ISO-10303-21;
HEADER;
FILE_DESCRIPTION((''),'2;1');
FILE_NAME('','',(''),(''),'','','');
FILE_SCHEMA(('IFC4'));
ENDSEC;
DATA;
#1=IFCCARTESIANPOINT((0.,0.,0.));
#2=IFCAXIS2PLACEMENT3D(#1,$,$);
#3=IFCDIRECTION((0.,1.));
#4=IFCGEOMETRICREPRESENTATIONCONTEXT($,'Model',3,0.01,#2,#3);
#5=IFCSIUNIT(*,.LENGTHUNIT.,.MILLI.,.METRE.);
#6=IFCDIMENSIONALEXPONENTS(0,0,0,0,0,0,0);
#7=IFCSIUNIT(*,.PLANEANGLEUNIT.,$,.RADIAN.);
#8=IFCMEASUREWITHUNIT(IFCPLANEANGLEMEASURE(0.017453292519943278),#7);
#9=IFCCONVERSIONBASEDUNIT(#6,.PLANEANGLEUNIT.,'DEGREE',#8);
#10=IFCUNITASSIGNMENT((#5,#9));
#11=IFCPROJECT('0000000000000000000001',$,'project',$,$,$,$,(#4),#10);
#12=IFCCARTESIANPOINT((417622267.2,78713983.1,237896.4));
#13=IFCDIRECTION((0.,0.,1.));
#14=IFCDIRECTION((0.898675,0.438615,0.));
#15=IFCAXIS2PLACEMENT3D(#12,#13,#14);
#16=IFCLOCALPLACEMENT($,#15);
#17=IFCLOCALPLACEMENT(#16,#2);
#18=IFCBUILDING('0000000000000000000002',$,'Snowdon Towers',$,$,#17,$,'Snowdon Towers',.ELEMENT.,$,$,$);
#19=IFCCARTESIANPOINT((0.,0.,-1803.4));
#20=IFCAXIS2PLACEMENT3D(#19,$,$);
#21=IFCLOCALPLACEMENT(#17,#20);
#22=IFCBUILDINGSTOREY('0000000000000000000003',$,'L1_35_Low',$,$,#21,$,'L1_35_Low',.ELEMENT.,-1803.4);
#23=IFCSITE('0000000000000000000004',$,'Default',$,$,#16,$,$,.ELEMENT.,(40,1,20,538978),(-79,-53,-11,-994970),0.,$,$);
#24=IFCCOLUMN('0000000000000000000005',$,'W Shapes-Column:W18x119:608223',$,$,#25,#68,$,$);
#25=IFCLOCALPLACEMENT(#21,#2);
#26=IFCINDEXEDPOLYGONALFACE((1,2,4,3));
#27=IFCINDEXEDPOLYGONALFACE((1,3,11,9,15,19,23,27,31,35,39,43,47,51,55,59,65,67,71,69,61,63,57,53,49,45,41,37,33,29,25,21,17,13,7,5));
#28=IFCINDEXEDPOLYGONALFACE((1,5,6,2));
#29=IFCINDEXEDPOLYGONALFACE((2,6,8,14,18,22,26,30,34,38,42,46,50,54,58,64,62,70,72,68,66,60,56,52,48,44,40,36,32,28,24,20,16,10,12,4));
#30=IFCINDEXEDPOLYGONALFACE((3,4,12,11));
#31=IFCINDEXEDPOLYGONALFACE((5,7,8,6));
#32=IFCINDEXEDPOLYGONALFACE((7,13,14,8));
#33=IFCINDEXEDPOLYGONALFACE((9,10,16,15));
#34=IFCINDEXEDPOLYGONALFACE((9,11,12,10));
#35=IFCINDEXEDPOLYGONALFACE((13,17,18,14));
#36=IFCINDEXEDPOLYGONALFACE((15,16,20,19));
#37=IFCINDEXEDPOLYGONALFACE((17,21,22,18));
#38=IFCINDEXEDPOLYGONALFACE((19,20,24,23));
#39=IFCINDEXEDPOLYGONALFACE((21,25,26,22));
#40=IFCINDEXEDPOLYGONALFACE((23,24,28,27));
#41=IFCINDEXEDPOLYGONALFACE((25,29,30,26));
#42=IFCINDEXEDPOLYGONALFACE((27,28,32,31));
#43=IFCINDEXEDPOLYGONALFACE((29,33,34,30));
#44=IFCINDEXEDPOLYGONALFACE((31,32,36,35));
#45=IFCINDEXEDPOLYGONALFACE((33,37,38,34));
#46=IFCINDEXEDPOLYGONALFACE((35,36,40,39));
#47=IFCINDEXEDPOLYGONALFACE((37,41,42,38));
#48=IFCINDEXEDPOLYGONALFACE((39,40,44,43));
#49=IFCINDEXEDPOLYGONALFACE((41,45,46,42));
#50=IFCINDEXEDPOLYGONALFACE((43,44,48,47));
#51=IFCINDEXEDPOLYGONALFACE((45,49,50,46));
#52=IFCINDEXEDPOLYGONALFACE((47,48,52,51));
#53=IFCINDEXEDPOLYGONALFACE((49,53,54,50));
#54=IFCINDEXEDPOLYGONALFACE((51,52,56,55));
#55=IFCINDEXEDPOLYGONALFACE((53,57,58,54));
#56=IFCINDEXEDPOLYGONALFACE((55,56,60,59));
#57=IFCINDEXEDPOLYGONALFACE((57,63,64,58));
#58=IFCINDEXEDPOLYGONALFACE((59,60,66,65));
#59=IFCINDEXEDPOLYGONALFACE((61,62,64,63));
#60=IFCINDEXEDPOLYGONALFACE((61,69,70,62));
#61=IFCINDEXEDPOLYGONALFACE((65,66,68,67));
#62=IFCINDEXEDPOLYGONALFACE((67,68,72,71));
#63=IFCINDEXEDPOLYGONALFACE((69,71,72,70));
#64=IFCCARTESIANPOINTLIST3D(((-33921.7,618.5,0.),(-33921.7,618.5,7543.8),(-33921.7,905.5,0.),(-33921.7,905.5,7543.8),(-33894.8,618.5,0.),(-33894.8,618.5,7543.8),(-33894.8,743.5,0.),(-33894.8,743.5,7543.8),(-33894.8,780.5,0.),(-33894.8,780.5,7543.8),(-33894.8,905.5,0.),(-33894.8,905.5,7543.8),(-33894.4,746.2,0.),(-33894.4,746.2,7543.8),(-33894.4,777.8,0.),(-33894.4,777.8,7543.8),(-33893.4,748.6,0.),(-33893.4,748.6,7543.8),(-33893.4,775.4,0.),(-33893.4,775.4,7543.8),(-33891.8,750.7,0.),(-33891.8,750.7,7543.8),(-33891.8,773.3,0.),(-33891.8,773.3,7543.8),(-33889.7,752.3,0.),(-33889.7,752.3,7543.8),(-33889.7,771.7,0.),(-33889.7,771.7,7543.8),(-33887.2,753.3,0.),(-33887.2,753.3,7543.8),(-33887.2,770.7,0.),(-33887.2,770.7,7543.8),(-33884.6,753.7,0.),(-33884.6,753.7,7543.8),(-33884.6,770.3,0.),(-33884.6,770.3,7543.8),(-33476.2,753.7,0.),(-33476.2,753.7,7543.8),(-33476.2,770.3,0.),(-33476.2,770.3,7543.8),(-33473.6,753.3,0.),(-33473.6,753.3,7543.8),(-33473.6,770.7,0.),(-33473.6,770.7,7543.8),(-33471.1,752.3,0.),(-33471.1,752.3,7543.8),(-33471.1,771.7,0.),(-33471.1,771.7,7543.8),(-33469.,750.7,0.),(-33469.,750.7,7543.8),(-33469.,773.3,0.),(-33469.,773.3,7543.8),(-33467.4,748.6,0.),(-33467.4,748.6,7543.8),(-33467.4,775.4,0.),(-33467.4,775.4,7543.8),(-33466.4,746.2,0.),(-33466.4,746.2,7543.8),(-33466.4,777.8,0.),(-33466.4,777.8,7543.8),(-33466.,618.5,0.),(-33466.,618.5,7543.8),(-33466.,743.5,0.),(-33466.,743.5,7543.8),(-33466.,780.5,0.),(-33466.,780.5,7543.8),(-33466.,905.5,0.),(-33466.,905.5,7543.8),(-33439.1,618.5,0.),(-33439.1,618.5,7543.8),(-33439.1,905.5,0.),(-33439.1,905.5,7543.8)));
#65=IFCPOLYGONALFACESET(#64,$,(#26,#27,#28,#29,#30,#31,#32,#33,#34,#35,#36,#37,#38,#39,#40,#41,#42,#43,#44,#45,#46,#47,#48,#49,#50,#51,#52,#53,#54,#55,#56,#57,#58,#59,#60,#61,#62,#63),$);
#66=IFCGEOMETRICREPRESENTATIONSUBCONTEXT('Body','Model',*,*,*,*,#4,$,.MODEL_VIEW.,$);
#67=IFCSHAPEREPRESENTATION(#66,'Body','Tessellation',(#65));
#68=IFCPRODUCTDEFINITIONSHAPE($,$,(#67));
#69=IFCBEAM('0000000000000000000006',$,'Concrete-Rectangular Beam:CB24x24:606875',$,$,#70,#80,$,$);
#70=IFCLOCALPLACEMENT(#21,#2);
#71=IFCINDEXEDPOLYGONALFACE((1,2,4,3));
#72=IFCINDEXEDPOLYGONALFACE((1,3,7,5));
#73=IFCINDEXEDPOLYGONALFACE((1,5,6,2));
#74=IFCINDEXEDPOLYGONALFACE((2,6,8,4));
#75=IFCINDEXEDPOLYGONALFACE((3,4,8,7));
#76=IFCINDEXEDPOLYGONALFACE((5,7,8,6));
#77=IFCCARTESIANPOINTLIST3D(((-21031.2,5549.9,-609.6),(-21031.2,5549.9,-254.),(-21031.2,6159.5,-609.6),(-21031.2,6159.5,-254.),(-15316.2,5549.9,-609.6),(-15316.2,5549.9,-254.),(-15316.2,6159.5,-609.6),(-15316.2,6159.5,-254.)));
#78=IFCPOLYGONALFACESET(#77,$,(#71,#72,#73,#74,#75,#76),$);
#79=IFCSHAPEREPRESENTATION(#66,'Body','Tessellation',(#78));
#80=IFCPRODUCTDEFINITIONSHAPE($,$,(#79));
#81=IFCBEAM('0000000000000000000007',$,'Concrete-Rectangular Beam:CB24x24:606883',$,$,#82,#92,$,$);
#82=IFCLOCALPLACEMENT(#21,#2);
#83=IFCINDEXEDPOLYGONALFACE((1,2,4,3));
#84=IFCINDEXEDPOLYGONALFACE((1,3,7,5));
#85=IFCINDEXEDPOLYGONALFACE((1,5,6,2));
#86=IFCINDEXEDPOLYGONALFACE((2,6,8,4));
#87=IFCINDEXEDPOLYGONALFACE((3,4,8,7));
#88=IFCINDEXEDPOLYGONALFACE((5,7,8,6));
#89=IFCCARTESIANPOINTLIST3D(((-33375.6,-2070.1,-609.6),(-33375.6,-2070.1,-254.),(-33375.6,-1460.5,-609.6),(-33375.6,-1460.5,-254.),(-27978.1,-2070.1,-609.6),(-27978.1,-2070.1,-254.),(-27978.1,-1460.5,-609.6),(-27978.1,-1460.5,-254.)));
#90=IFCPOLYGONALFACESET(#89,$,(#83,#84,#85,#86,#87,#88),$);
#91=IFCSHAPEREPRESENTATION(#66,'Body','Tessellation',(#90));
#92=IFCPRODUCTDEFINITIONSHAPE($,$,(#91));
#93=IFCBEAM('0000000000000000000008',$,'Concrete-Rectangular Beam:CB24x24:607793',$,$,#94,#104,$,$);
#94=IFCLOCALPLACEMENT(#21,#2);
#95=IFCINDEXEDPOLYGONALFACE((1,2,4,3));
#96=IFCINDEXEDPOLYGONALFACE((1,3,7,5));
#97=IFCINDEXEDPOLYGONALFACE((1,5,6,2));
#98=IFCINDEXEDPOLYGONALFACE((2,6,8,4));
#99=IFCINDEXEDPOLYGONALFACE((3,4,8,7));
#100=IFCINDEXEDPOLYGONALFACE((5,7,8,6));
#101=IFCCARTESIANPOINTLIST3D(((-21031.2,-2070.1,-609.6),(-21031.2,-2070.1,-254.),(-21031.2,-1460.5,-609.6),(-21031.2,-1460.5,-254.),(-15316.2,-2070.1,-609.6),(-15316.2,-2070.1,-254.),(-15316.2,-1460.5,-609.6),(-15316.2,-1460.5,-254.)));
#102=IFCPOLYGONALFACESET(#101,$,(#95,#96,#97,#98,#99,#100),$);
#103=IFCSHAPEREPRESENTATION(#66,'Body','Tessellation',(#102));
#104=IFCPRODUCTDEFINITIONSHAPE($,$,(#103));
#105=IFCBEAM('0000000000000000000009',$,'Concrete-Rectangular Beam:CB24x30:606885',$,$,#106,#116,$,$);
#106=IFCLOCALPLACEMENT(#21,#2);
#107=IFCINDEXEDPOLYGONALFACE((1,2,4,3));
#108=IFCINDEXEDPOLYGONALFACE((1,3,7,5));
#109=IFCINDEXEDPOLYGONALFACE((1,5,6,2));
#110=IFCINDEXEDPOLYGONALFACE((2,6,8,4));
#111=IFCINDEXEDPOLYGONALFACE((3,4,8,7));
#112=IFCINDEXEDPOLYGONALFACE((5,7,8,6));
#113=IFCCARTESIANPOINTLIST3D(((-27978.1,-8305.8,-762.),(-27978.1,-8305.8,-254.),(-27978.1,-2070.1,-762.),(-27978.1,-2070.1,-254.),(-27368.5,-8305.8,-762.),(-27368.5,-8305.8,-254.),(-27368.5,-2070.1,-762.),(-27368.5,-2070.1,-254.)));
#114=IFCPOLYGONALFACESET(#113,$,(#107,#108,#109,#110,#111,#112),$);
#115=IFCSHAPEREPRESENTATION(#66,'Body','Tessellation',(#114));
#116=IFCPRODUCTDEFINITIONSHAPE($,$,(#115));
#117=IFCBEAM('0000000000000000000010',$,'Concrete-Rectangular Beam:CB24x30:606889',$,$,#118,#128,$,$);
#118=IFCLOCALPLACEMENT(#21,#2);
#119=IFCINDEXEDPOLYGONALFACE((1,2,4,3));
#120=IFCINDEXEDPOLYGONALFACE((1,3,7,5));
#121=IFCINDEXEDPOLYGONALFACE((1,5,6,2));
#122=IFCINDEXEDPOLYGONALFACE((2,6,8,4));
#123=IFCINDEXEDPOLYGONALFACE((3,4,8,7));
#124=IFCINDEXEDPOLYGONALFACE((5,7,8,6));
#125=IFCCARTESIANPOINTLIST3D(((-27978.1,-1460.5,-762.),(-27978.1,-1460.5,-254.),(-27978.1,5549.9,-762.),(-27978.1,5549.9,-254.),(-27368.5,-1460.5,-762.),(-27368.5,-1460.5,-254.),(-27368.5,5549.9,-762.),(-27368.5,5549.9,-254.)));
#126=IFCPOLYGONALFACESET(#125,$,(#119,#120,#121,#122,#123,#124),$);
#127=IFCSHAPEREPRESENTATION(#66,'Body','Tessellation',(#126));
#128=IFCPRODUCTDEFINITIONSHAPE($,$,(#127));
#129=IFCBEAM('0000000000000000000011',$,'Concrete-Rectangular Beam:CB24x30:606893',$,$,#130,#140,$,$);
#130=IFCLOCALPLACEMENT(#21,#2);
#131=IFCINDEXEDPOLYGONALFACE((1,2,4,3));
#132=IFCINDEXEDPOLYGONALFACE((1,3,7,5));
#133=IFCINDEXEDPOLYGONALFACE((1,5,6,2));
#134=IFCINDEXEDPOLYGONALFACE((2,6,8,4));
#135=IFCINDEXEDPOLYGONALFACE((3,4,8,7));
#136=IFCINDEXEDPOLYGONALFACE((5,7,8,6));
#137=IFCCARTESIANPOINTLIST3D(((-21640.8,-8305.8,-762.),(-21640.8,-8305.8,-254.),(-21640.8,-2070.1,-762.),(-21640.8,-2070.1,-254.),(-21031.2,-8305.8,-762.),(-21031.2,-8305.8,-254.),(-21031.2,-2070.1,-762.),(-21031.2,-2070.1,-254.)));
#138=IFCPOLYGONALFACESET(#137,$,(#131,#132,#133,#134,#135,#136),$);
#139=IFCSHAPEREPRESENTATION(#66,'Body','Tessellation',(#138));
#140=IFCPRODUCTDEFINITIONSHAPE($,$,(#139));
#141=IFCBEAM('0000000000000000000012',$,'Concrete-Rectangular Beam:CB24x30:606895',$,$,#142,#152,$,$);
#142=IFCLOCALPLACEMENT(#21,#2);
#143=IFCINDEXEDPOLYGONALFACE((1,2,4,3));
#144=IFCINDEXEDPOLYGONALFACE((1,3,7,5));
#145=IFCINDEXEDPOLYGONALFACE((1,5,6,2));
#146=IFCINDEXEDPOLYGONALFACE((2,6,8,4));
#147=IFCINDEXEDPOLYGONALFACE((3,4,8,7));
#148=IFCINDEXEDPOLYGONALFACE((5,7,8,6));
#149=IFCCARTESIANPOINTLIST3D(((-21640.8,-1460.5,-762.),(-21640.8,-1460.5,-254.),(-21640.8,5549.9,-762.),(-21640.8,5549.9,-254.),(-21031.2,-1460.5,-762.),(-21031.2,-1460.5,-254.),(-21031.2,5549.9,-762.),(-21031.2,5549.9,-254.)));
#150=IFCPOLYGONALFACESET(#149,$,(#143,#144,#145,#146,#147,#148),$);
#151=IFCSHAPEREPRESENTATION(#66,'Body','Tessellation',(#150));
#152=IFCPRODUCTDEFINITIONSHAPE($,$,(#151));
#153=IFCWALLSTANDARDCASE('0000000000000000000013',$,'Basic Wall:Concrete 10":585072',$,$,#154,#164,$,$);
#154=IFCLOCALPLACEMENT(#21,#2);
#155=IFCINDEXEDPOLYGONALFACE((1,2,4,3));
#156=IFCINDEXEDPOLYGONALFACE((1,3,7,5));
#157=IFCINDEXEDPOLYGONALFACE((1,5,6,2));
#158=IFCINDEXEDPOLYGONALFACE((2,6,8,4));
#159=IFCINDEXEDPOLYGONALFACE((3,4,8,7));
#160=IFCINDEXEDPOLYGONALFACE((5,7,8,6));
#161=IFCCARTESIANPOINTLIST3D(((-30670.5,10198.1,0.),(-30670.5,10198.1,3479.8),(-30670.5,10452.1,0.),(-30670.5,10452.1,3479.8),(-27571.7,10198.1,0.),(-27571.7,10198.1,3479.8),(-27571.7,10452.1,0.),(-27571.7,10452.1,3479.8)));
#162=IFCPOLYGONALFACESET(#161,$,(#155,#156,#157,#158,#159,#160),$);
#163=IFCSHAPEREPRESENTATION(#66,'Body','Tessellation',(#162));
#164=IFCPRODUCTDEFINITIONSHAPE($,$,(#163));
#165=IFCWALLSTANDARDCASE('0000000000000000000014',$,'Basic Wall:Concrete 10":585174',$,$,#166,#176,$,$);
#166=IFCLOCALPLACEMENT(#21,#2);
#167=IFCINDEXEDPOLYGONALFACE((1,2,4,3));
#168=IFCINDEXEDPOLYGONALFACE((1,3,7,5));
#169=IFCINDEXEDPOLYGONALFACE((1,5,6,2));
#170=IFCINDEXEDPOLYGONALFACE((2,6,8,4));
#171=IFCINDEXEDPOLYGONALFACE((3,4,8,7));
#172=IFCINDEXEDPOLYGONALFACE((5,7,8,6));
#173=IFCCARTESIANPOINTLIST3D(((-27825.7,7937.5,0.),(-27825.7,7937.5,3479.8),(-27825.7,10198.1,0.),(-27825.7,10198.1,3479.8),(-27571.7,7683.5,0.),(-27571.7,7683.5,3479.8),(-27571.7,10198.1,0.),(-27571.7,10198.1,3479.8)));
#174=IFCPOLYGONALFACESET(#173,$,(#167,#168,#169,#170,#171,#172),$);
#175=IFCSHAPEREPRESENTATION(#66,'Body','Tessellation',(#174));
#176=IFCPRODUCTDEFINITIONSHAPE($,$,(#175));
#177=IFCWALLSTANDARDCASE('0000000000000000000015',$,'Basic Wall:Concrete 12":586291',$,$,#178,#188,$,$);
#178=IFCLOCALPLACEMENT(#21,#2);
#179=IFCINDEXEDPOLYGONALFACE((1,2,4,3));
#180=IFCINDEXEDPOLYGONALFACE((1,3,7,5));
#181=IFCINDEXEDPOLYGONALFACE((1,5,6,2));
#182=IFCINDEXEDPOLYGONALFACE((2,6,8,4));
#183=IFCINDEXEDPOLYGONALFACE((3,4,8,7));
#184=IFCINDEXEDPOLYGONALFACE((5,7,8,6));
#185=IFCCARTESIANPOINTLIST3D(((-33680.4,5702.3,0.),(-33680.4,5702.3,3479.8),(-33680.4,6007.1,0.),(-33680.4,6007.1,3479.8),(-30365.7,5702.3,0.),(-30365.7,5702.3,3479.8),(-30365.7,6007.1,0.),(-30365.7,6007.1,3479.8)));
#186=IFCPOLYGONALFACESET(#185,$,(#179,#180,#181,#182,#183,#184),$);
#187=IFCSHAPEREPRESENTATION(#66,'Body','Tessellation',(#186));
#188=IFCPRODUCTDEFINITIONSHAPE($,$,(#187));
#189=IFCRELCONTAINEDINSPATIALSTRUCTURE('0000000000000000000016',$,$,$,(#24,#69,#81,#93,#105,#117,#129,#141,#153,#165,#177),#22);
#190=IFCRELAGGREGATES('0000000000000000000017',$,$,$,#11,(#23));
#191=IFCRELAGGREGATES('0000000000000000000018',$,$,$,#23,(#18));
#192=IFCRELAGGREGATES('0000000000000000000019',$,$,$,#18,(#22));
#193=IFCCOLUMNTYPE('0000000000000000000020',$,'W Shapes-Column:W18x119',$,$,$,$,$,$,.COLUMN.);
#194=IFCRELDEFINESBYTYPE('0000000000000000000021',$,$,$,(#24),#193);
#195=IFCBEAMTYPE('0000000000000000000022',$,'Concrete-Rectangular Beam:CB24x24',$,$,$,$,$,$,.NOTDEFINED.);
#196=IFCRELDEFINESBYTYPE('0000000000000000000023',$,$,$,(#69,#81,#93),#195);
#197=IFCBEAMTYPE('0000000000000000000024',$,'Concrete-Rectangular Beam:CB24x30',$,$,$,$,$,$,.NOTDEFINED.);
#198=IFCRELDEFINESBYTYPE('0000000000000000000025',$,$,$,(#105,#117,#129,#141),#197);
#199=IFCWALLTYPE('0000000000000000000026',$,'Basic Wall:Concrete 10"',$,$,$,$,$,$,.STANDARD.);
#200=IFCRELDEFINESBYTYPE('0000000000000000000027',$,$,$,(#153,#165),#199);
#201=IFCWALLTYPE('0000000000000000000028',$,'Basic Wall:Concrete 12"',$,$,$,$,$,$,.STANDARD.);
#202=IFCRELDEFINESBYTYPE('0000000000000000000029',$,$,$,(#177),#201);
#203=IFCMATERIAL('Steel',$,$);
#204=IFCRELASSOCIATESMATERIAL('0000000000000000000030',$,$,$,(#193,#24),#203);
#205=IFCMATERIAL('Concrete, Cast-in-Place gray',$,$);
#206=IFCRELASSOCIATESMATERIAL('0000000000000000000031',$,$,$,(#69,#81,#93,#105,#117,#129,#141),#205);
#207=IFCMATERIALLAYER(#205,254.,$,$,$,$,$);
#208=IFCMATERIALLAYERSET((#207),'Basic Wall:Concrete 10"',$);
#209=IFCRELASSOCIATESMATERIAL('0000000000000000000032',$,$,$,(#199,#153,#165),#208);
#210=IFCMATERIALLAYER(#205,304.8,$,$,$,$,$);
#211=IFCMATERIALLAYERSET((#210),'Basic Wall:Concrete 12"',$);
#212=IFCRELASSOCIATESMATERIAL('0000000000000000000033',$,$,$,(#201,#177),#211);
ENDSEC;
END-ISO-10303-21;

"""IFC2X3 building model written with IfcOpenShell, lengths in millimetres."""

from ifc_helpers import new_model, entity, si_unit, converted_unit, direction, frame, frame_2d, origin, place, context, subcontext, project, spatial, polyline, rectangle, i_section, outline, extrude, source, transform, mapped, material, layer, layer_set, layer_usage, type_object, type_shapes, element, save


model = new_model("IFC2X3")

# Units and contexts
model_context = context("Model", 3, precision=0.01, world=origin(), true_north=direction((0.0, 1.0)))
body_context = subcontext(model_context, "Body", "Model", "MODEL_VIEW")
ifc_project = project(units=[si_unit("LENGTHUNIT", "METRE", prefix="MILLI"), converted_unit("PLANEANGLEUNIT", "DEGREE", entity("IfcPlaneAngleMeasure", 0.017453292519943278), si_unit("PLANEANGLEUNIT", "RADIAN"), dimensions=[0, 0, 0, 0, 0, 0, 0])], contexts=[model_context])

# Site, building, storey
site_placement = place(None, frame((417622267.2, 78713983.1, 237896.4), z_axis=(0.0, 0.0, 1.0), x_axis=(0.898675, 0.438615, 0.0)))
site = spatial("IfcSite", under=ifc_project, at=site_placement, Name="Default", CompositionType="ELEMENT", RefLatitude=(40, 1, 20, 538978), RefLongitude=(-79, -53, -11, -994970), RefElevation=0.0)
building_placement = place(site_placement, origin())
building = spatial("IfcBuilding", under=site, at=building_placement, Name="Snowdon Towers", LongName="Snowdon Towers", CompositionType="ELEMENT")
storey_placement = place(building_placement, frame((0.0, 0.0, -1803.4)))
storey = spatial("IfcBuildingStorey", under=building, at=storey_placement, Name="L1_35_Low", LongName="L1_35_Low", CompositionType="ELEMENT", Elevation=-1803.4)

# Column
ifc_material_1 = material(Name="Steel")
column_type_1 = type_object("IfcColumnType", Name="W Shapes-Column:W18x119", PredefinedType="COLUMN", material=ifc_material_1)
shared_shape_1 = source(origin(), body_context, "Body", "SweptSolid", [
    extrude(i_section(OverallWidth=287.0, OverallDepth=482.6, WebThickness=16.6, FlangeThickness=26.9, FilletRadius=10.2, at=frame_2d((0.0, 0.0), x_axis=(1.0, 0.0))), frame((0.0, 0.0, -1803.4), z_axis=(0.0, 0.0, 1.0), x_axis=(-1.0, 0.0, 0.0)), (0.0, 0.0, 1.0), 7543.8),
])
type_shapes(column_type_1, [shared_shape_1])
column_placement = place(storey_placement, frame((-33680.4, 762.0, 1803.4), z_axis=(0.0, 0.0, 1.0), x_axis=(0.0, -1.0, 0.0)))
element("IfcColumn", 1, at=column_placement, inside=storey, type_object=column_type_1, material=ifc_material_1, Name="W Shapes-Column:W18x119:608223", context=body_context, shape_type="MappedRepresentation", body=[
    mapped(shared_shape_1, transform((0.0, 0.0, 0.0), scale=1.0)),
])

# Beams
ifc_material_2 = material(Name="Concrete, Cast-in-Place gray")
beam_type_1 = type_object("IfcBeamType", Name="Concrete-Rectangular Beam:CB24x24", PredefinedType="NOTDEFINED")
beam_1_placement = place(storey_placement, frame((-21336.0, 5854.7, 0.0)))
element("IfcBeam", 2, at=beam_1_placement, inside=storey, type_object=beam_type_1, material=ifc_material_2, Name="Concrete-Rectangular Beam:CB24x24:606875", context=body_context, shape_type="SweptSolid", body=[
    extrude(rectangle(XDim=355.6, YDim=609.6, at=frame_2d((0.0, 0.0), x_axis=(1.0, 0.0))), frame((304.8, 0.0, -431.8), z_axis=(1.0, 0.0, 0.0), x_axis=(0.0, 0.0, -1.0)), (0.0, 0.0, 1.0), 5715.0),
])
beam_2_placement = place(storey_placement, frame((-33680.4, -1765.3, 0.0)))
element("IfcBeam", 3, at=beam_2_placement, inside=storey, type_object=beam_type_1, material=ifc_material_2, Name="Concrete-Rectangular Beam:CB24x24:606883", context=body_context, shape_type="SweptSolid", body=[
    extrude(rectangle(XDim=355.6, YDim=609.6, at=frame_2d((0.0, 0.0), x_axis=(1.0, 0.0))), frame((304.8, 0.0, -431.8), z_axis=(1.0, 0.0, 0.0), x_axis=(0.0, 0.0, -1.0)), (0.0, 0.0, 1.0), 5397.5),
])
beam_3_placement = place(storey_placement, frame((-21336.0, -1765.3, 0.0)))
element("IfcBeam", 4, at=beam_3_placement, inside=storey, type_object=beam_type_1, material=ifc_material_2, Name="Concrete-Rectangular Beam:CB24x24:607793", context=body_context, shape_type="SweptSolid", body=[
    extrude(rectangle(XDim=355.6, YDim=609.6, at=frame_2d((0.0, 0.0), x_axis=(1.0, 0.0))), frame((304.8, 0.0, -431.8), z_axis=(1.0, 0.0, 0.0), x_axis=(0.0, 0.0, -1.0)), (0.0, 0.0, 1.0), 5715.0),
])
beam_type_2 = type_object("IfcBeamType", Name="Concrete-Rectangular Beam:CB24x30", PredefinedType="NOTDEFINED")
beam_4_placement = place(storey_placement, frame((-27673.3, -8610.6, 0.0), z_axis=(0.0, 0.0, 1.0), x_axis=(0.0, 1.0, 0.0)))
element("IfcBeam", 5, at=beam_4_placement, inside=storey, type_object=beam_type_2, material=ifc_material_2, Name="Concrete-Rectangular Beam:CB24x30:606885", context=body_context, shape_type="SweptSolid", body=[
    extrude(rectangle(XDim=508.0, YDim=609.6, at=frame_2d((0.0, 0.0), x_axis=(1.0, 0.0))), frame((304.8, 0.0, -508.0), z_axis=(1.0, 0.0, 0.0), x_axis=(0.0, 0.0, -1.0)), (0.0, 0.0, 1.0), 6235.7),
])
beam_5_placement = place(storey_placement, frame((-27673.3, -1765.3, 0.0), z_axis=(0.0, 0.0, 1.0), x_axis=(0.0, 1.0, 0.0)))
element("IfcBeam", 6, at=beam_5_placement, inside=storey, type_object=beam_type_2, material=ifc_material_2, Name="Concrete-Rectangular Beam:CB24x30:606889", context=body_context, shape_type="SweptSolid", body=[
    extrude(rectangle(XDim=508.0, YDim=609.6, at=frame_2d((0.0, 0.0), x_axis=(1.0, 0.0))), frame((304.8, 0.0, -508.0), z_axis=(1.0, 0.0, 0.0), x_axis=(0.0, 0.0, -1.0)), (0.0, 0.0, 1.0), 7010.4),
])
beam_6_placement = place(storey_placement, frame((-21336.0, -8610.6, 0.0), z_axis=(0.0, 0.0, 1.0), x_axis=(0.0, 1.0, 0.0)))
element("IfcBeam", 7, at=beam_6_placement, inside=storey, type_object=beam_type_2, material=ifc_material_2, Name="Concrete-Rectangular Beam:CB24x30:606893", context=body_context, shape_type="SweptSolid", body=[
    extrude(rectangle(XDim=508.0, YDim=609.6, at=frame_2d((0.0, 0.0), x_axis=(1.0, 0.0))), frame((304.8, 0.0, -508.0), z_axis=(1.0, 0.0, 0.0), x_axis=(0.0, 0.0, -1.0)), (0.0, 0.0, 1.0), 6235.7),
])
beam_7_placement = place(storey_placement, frame((-21336.0, -1765.3, 0.0), z_axis=(0.0, 0.0, 1.0), x_axis=(0.0, 1.0, 0.0)))
element("IfcBeam", 8, at=beam_7_placement, inside=storey, type_object=beam_type_2, material=ifc_material_2, Name="Concrete-Rectangular Beam:CB24x30:606895", context=body_context, shape_type="SweptSolid", body=[
    extrude(rectangle(XDim=508.0, YDim=609.6, at=frame_2d((0.0, 0.0), x_axis=(1.0, 0.0))), frame((304.8, 0.0, -508.0), z_axis=(1.0, 0.0, 0.0), x_axis=(0.0, 0.0, -1.0)), (0.0, 0.0, 1.0), 7010.4),
])

# Walls
ifc_layer_1 = layer(ifc_material_2, 254.0)
ifc_layer_set_1 = layer_set([ifc_layer_1], Name="Basic Wall:Concrete 10\"")
ifc_layer_usage_1 = layer_usage(ifc_layer_set_1, "AXIS2", "POSITIVE", -127.0)
wall_type_1 = type_object("IfcWallType", Name="Basic Wall:Concrete 10\"", PredefinedType="STANDARD", material=ifc_layer_set_1)
wall_1_placement = place(storey_placement, frame((-30670.5, 10325.1, 0.0)))
element("IfcWallStandardCase", 9, at=wall_1_placement, inside=storey, type_object=wall_type_1, material=ifc_layer_usage_1, Name="Basic Wall:Concrete 10\":585072", context=body_context, shape_type="SweptSolid", body=[
    extrude(rectangle(XDim=3098.8, YDim=254.0, at=frame_2d((1549.4, 0.0), x_axis=(-1.0, 0.0))), origin(), (0.0, 0.0, 1.0), 3479.8),
])
ifc_layer_usage_2 = layer_usage(ifc_layer_set_1, "AXIS2", "POSITIVE", -127.0)
wall_2_placement = place(storey_placement, frame((-27698.7, 10198.1, 0.0), z_axis=(0.0, 0.0, 1.0), x_axis=(0.0, -1.0, 0.0)))
element("IfcWallStandardCase", 10, at=wall_2_placement, inside=storey, type_object=wall_type_1, material=ifc_layer_usage_2, Name="Basic Wall:Concrete 10\":585174", context=body_context, shape_type="SweptSolid", body=[
    extrude(outline(polyline([(2260.6, -127.0), (2514.6, 127.0), (0.0, 127.0), (0.0, -127.0), (2260.6, -127.0)])), origin(), (0.0, 0.0, 1.0), 3479.8),
])
ifc_layer_2 = layer(ifc_material_2, 304.8)
ifc_layer_set_2 = layer_set([ifc_layer_2], Name="Basic Wall:Concrete 12\"")
ifc_layer_usage_3 = layer_usage(ifc_layer_set_2, "AXIS2", "POSITIVE", -152.4)
wall_type_2 = type_object("IfcWallType", Name="Basic Wall:Concrete 12\"", PredefinedType="STANDARD", material=ifc_layer_set_2)
wall_3_placement = place(storey_placement, frame((-30365.7, 5854.7, 0.0), z_axis=(0.0, 0.0, 1.0), x_axis=(-1.0, 0.0, 0.0)))
element("IfcWallStandardCase", 11, at=wall_3_placement, inside=storey, type_object=wall_type_2, material=ifc_layer_usage_3, Name="Basic Wall:Concrete 12\":586291", context=body_context, shape_type="SweptSolid", body=[
    extrude(rectangle(XDim=3314.7, YDim=304.8, at=frame_2d((1657.4, 0.0), x_axis=(-1.0, 0.0))), origin(), (0.0, 0.0, 1.0), 3479.8),
])

save(model, "model.ifc")
